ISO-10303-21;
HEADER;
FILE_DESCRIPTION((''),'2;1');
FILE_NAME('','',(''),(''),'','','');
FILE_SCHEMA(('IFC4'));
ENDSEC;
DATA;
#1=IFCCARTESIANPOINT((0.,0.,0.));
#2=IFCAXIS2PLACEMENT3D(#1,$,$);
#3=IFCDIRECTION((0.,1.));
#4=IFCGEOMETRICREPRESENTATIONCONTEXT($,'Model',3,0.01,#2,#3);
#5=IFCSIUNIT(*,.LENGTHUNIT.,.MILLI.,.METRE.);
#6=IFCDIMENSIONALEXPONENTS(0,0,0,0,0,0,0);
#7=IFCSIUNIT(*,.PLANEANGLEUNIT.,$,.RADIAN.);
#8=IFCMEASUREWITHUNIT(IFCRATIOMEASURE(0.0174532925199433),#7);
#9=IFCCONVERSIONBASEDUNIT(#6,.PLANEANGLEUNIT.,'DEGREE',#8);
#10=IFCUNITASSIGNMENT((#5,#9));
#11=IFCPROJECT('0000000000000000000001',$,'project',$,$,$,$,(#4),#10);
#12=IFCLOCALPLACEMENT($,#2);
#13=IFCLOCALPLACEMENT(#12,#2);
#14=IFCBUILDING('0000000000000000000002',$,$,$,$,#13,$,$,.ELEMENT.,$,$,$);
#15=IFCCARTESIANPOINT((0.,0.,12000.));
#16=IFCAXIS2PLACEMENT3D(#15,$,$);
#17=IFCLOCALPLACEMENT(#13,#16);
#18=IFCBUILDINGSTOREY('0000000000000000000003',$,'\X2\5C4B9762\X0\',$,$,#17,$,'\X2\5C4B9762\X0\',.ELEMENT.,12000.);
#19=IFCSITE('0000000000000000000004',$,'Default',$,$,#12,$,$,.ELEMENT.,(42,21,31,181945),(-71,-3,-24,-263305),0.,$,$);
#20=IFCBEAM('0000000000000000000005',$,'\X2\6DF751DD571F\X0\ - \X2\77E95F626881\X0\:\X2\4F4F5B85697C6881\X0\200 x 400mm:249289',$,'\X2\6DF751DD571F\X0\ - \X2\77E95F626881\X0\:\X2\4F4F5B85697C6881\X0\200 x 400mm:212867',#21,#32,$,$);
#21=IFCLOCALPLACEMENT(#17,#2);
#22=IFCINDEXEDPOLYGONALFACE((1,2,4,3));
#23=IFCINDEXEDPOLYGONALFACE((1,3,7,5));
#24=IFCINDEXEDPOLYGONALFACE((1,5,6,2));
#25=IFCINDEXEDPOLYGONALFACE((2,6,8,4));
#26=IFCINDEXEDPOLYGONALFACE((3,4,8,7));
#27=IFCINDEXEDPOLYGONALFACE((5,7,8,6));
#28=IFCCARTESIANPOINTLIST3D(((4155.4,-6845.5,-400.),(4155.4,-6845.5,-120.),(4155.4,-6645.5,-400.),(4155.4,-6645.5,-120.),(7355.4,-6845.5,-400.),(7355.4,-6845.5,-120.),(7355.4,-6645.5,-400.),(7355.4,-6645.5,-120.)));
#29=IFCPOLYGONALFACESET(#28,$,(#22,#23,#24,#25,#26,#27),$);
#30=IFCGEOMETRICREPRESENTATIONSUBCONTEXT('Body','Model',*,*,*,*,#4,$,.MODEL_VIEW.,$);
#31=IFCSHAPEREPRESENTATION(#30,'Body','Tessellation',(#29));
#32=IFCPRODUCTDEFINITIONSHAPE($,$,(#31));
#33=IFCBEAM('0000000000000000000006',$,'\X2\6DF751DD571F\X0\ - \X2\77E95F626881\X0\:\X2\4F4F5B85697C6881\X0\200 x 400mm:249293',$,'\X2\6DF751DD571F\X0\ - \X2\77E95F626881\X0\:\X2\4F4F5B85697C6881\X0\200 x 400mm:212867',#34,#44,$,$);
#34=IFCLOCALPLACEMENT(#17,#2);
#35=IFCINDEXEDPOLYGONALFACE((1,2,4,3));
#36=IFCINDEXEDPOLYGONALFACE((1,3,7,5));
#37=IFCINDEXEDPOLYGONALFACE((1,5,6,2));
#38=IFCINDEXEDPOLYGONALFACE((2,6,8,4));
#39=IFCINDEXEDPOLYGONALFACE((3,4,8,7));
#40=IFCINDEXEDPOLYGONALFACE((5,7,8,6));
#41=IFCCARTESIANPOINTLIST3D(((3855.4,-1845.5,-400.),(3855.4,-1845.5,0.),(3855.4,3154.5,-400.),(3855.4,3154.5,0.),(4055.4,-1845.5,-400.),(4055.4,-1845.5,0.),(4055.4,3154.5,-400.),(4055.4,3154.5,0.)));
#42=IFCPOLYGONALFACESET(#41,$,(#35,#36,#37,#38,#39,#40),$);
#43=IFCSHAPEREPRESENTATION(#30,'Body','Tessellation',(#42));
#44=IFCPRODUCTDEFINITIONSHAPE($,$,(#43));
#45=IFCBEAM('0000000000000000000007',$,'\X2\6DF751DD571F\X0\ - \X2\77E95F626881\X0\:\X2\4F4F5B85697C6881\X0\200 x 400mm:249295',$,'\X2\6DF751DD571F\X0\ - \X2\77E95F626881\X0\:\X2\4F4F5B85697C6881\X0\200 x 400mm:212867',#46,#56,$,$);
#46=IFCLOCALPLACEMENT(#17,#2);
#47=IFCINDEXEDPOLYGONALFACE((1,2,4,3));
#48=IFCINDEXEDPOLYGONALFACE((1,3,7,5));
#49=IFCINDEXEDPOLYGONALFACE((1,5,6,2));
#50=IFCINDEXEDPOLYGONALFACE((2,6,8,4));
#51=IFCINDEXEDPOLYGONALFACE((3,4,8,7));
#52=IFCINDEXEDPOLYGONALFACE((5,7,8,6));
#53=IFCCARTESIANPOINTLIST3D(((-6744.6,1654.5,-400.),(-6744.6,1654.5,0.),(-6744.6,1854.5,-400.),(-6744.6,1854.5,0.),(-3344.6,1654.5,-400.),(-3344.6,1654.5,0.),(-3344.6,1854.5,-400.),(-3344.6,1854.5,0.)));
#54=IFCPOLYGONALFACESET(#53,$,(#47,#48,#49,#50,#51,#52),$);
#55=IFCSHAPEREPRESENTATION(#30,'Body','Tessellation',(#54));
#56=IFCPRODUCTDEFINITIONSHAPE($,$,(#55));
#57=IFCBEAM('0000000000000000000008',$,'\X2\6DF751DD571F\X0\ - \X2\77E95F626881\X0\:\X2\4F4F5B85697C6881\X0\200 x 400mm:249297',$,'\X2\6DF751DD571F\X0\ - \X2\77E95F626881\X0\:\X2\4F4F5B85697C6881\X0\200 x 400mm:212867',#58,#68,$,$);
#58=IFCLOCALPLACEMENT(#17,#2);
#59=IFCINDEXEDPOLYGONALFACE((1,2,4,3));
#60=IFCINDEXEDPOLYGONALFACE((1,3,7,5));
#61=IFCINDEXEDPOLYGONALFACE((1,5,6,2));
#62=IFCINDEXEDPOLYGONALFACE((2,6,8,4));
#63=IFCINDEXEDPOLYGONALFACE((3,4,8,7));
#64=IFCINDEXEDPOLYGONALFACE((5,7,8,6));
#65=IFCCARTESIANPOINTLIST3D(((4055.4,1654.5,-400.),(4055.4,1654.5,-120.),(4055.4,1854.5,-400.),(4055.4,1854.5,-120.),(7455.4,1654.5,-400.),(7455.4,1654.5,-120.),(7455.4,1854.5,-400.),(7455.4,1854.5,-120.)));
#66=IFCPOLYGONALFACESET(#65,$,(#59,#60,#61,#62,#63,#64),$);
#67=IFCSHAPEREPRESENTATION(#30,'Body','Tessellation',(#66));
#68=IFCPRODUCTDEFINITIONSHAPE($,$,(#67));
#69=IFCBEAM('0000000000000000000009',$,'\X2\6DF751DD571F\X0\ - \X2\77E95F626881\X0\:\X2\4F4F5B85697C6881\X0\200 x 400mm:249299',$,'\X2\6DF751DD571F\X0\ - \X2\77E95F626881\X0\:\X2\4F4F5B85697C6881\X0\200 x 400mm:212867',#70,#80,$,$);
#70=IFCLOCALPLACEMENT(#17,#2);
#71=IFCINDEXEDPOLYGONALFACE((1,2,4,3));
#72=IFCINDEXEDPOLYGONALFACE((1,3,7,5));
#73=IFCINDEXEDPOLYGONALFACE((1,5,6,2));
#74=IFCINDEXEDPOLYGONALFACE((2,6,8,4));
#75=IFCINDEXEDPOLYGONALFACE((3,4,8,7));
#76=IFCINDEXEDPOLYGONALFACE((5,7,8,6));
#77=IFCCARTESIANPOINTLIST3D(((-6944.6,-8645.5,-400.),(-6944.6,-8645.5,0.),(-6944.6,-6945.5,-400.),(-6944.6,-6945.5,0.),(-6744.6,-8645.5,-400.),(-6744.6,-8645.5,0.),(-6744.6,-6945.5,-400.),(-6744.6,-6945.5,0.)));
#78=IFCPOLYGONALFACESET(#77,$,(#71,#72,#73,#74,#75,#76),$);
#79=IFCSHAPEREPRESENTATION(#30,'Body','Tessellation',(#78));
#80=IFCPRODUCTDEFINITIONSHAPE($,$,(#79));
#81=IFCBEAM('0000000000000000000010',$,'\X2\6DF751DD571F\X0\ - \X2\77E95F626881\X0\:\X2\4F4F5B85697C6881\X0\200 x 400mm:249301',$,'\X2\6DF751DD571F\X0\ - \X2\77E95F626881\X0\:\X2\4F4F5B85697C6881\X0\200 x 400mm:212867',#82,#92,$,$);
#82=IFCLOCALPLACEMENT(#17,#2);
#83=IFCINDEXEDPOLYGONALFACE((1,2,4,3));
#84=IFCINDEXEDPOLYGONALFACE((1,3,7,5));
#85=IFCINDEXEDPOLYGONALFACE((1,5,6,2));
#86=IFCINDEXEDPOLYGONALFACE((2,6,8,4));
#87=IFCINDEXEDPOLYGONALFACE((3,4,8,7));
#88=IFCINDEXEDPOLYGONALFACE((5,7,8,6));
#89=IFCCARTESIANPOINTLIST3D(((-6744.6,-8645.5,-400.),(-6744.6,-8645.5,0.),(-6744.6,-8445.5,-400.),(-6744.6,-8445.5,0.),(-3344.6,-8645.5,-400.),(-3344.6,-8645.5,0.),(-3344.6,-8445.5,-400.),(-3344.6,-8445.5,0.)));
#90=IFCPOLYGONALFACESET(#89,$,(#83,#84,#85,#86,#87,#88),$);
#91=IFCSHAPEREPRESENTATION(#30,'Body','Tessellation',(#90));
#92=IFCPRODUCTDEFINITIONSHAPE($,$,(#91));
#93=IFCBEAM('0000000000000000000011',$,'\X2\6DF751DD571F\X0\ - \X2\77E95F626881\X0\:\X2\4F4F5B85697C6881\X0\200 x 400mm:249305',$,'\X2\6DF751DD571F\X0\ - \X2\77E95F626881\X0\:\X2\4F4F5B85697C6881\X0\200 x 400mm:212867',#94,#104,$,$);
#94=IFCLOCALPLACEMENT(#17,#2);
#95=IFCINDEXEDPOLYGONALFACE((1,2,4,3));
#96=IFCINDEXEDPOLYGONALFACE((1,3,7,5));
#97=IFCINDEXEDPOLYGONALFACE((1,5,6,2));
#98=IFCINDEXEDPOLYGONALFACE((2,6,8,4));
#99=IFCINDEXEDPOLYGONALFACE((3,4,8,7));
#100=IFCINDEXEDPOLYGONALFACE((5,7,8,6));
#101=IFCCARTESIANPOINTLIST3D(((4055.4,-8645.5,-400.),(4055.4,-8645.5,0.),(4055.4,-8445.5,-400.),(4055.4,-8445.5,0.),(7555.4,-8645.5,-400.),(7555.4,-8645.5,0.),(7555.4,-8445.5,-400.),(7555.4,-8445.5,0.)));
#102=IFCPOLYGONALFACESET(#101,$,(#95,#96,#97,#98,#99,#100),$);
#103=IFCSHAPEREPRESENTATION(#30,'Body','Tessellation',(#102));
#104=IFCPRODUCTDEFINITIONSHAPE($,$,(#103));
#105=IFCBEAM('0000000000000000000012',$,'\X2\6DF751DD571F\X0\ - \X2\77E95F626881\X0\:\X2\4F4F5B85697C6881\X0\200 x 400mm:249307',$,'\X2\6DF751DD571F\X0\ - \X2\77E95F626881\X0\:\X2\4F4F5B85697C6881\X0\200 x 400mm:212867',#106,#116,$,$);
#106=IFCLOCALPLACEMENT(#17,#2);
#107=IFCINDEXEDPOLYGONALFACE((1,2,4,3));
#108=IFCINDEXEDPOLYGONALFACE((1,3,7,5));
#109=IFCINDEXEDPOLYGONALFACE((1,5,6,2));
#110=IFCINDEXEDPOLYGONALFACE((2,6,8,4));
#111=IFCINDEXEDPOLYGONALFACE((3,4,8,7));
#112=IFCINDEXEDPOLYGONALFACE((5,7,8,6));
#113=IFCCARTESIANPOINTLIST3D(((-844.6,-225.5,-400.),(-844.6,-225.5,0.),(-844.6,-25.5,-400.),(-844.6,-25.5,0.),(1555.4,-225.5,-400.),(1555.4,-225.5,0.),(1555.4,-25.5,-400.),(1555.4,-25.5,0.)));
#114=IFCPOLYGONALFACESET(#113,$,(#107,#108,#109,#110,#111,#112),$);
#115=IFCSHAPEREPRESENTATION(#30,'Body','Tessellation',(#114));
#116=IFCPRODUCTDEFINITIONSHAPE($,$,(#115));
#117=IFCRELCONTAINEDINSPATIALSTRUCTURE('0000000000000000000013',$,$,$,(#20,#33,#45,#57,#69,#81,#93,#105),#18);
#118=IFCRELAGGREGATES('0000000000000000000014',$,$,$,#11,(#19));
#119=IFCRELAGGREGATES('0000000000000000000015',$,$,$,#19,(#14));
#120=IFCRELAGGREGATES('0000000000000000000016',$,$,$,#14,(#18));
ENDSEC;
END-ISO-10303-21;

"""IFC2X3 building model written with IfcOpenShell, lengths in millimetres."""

from ifc_helpers import new_model, entity, si_unit, converted_unit, direction, frame, frame_2d, origin, origin_2d_with_axis, place, context, subcontext, project, spatial, rectangle, extrude, element, save


model = new_model("IFC2X3")

# Units and contexts
model_context = context("Model", 3, precision=0.01, world=origin(), true_north=direction((0.0, 1.0)))
body_context = subcontext(model_context, "Body", "Model", "MODEL_VIEW")
ifc_project = project(units=[si_unit("LENGTHUNIT", "METRE", prefix="MILLI"), converted_unit("PLANEANGLEUNIT", "DEGREE", entity("IfcRatioMeasure", 0.0174532925199433), si_unit("PLANEANGLEUNIT", "RADIAN"), dimensions=[0, 0, 0, 0, 0, 0, 0])], contexts=[model_context])

# Site, building, storey
site_placement = place(None, origin())
site = spatial("IfcSite", under=ifc_project, at=site_placement, Name="Default", CompositionType="ELEMENT", RefLatitude=(42, 21, 31, 181945), RefLongitude=(-71, -3, -24, -263305), RefElevation=0.0)
building_placement = place(site_placement, origin())
building = spatial("IfcBuilding", under=site, at=building_placement, CompositionType="ELEMENT")
storey_placement = place(building_placement, frame((0.0, 0.0, 12000.0)))
storey = spatial("IfcBuildingStorey", under=building, at=storey_placement, Name="屋面", LongName="屋面", CompositionType="ELEMENT", Elevation=12000.0)

# Beams
beam_1_placement = place(storey_placement, frame((3955.4, -6745.5, 0.0)))
element("IfcBeam", 1, at=beam_1_placement, inside=storey, Name="混凝土 - 矩形梁:住宅楼梁200 x 400mm:249289", ObjectType="混凝土 - 矩形梁:住宅楼梁200 x 400mm:212867", context=body_context, shape_type="SweptSolid", body=[
    extrude(rectangle(XDim=280.0, YDim=200.0, at=frame_2d((0.0, 0.0), x_axis=(1.0, 0.0))), frame((200.0, 0.0, -260.0), z_axis=(1.0, 0.0, 0.0), x_axis=(0.0, 0.0, -1.0)), (0.0, 0.0, 1.0), 3200.0),
])
beam_2_placement = place(storey_placement, frame((3955.4, 3254.5, 0.0), z_axis=(0.0, 0.0, 1.0), x_axis=(0.0, -1.0, 0.0)))
element("IfcBeam", 2, at=beam_2_placement, inside=storey, Name="混凝土 - 矩形梁:住宅楼梁200 x 400mm:249293", ObjectType="混凝土 - 矩形梁:住宅楼梁200 x 400mm:212867", context=body_context, shape_type="SweptSolid", body=[
    extrude(rectangle(XDim=400.0, YDim=200.0, at=frame_2d((0.0, 0.0), x_axis=(1.0, 0.0))), frame((100.0, 0.0, -200.0), z_axis=(1.0, 0.0, 0.0), x_axis=(0.0, 0.0, -1.0)), (0.0, 0.0, 1.0), 5000.0),
])
beam_3_placement = place(storey_placement, frame((-6844.6, 1754.5, 0.0)))
element("IfcBeam", 3, at=beam_3_placement, inside=storey, Name="混凝土 - 矩形梁:住宅楼梁200 x 400mm:249295", ObjectType="混凝土 - 矩形梁:住宅楼梁200 x 400mm:212867", context=body_context, shape_type="SweptSolid", body=[
    extrude(rectangle(XDim=400.0, YDim=200.0, at=frame_2d((0.0, 0.0), x_axis=(1.0, 0.0))), frame((100.0, 0.0, -200.0), z_axis=(1.0, 0.0, 0.0), x_axis=(0.0, 0.0, -1.0)), (0.0, 0.0, 1.0), 3400.0),
])
beam_4_placement = place(storey_placement, frame((7555.4, 1754.5, 0.0), z_axis=(0.0, 0.0, 1.0), x_axis=(-1.0, 0.0, 0.0)))
element("IfcBeam", 4, at=beam_4_placement, inside=storey, Name="混凝土 - 矩形梁:住宅楼梁200 x 400mm:249297", ObjectType="混凝土 - 矩形梁:住宅楼梁200 x 400mm:212867", context=body_context, shape_type="SweptSolid", body=[
    extrude(rectangle(XDim=280.0, YDim=200.0, at=frame_2d((0.0, 0.0), x_axis=(1.0, 0.0))), frame((100.0, 0.0, -260.0), z_axis=(1.0, 0.0, 0.0), x_axis=(0.0, 0.0, -1.0)), (0.0, 0.0, 1.0), 3400.0),
])
beam_5_placement = place(storey_placement, frame((-6844.6, -6745.5, 0.0), z_axis=(0.0, 0.0, 1.0), x_axis=(0.0, -1.0, 0.0)))
element("IfcBeam", 5, at=beam_5_placement, inside=storey, Name="混凝土 - 矩形梁:住宅楼梁200 x 400mm:249299", ObjectType="混凝土 - 矩形梁:住宅楼梁200 x 400mm:212867", context=body_context, shape_type="SweptSolid", body=[
    extrude(rectangle(XDim=400.0, YDim=200.0, at=origin_2d_with_axis()), frame((200.0, 0.0, -200.0), z_axis=(1.0, 0.0, 0.0), x_axis=(0.0, 0.0, -1.0)), (0.0, 0.0, 1.0), 1700.0),
])
beam_6_placement = place(storey_placement, frame((-6844.6, -8545.5, 0.0)))
element("IfcBeam", 6, at=beam_6_placement, inside=storey, Name="混凝土 - 矩形梁:住宅楼梁200 x 400mm:249301", ObjectType="混凝土 - 矩形梁:住宅楼梁200 x 400mm:212867", context=body_context, shape_type="SweptSolid", body=[
    extrude(rectangle(XDim=400.0, YDim=200.0, at=frame_2d((0.0, 0.0), x_axis=(1.0, 0.0))), frame((100.0, 0.0, -200.0), z_axis=(1.0, 0.0, 0.0), x_axis=(0.0, 0.0, -1.0)), (0.0, 0.0, 1.0), 3400.0),
])
beam_7_placement = place(storey_placement, frame((7555.4, -8545.5, 0.0), z_axis=(0.0, 0.0, 1.0), x_axis=(-1.0, 0.0, 0.0)))
element("IfcBeam", 7, at=beam_7_placement, inside=storey, Name="混凝土 - 矩形梁:住宅楼梁200 x 400mm:249305", ObjectType="混凝土 - 矩形梁:住宅楼梁200 x 400mm:212867", context=body_context, shape_type="SweptSolid", body=[
    extrude(rectangle(XDim=400.0, YDim=200.0, at=frame_2d((0.0, 0.0), x_axis=(1.0, 0.0))), frame((0.0, 0.0, -200.0), z_axis=(1.0, 0.0, 0.0), x_axis=(0.0, 0.0, -1.0)), (0.0, 0.0, 1.0), 3500.0),
])
beam_8_placement = place(storey_placement, frame((-944.6, -125.5, 0.0)))
element("IfcBeam", 8, at=beam_8_placement, inside=storey, Name="混凝土 - 矩形梁:住宅楼梁200 x 400mm:249307", ObjectType="混凝土 - 矩形梁:住宅楼梁200 x 400mm:212867", context=body_context, shape_type="SweptSolid", body=[
    extrude(rectangle(XDim=400.0, YDim=200.0, at=frame_2d((0.0, 0.0), x_axis=(1.0, 0.0))), frame((100.0, 0.0, -200.0), z_axis=(1.0, 0.0, 0.0), x_axis=(0.0, 0.0, -1.0)), (0.0, 0.0, 1.0), 2400.0),
])

save(model, "model.ifc")
